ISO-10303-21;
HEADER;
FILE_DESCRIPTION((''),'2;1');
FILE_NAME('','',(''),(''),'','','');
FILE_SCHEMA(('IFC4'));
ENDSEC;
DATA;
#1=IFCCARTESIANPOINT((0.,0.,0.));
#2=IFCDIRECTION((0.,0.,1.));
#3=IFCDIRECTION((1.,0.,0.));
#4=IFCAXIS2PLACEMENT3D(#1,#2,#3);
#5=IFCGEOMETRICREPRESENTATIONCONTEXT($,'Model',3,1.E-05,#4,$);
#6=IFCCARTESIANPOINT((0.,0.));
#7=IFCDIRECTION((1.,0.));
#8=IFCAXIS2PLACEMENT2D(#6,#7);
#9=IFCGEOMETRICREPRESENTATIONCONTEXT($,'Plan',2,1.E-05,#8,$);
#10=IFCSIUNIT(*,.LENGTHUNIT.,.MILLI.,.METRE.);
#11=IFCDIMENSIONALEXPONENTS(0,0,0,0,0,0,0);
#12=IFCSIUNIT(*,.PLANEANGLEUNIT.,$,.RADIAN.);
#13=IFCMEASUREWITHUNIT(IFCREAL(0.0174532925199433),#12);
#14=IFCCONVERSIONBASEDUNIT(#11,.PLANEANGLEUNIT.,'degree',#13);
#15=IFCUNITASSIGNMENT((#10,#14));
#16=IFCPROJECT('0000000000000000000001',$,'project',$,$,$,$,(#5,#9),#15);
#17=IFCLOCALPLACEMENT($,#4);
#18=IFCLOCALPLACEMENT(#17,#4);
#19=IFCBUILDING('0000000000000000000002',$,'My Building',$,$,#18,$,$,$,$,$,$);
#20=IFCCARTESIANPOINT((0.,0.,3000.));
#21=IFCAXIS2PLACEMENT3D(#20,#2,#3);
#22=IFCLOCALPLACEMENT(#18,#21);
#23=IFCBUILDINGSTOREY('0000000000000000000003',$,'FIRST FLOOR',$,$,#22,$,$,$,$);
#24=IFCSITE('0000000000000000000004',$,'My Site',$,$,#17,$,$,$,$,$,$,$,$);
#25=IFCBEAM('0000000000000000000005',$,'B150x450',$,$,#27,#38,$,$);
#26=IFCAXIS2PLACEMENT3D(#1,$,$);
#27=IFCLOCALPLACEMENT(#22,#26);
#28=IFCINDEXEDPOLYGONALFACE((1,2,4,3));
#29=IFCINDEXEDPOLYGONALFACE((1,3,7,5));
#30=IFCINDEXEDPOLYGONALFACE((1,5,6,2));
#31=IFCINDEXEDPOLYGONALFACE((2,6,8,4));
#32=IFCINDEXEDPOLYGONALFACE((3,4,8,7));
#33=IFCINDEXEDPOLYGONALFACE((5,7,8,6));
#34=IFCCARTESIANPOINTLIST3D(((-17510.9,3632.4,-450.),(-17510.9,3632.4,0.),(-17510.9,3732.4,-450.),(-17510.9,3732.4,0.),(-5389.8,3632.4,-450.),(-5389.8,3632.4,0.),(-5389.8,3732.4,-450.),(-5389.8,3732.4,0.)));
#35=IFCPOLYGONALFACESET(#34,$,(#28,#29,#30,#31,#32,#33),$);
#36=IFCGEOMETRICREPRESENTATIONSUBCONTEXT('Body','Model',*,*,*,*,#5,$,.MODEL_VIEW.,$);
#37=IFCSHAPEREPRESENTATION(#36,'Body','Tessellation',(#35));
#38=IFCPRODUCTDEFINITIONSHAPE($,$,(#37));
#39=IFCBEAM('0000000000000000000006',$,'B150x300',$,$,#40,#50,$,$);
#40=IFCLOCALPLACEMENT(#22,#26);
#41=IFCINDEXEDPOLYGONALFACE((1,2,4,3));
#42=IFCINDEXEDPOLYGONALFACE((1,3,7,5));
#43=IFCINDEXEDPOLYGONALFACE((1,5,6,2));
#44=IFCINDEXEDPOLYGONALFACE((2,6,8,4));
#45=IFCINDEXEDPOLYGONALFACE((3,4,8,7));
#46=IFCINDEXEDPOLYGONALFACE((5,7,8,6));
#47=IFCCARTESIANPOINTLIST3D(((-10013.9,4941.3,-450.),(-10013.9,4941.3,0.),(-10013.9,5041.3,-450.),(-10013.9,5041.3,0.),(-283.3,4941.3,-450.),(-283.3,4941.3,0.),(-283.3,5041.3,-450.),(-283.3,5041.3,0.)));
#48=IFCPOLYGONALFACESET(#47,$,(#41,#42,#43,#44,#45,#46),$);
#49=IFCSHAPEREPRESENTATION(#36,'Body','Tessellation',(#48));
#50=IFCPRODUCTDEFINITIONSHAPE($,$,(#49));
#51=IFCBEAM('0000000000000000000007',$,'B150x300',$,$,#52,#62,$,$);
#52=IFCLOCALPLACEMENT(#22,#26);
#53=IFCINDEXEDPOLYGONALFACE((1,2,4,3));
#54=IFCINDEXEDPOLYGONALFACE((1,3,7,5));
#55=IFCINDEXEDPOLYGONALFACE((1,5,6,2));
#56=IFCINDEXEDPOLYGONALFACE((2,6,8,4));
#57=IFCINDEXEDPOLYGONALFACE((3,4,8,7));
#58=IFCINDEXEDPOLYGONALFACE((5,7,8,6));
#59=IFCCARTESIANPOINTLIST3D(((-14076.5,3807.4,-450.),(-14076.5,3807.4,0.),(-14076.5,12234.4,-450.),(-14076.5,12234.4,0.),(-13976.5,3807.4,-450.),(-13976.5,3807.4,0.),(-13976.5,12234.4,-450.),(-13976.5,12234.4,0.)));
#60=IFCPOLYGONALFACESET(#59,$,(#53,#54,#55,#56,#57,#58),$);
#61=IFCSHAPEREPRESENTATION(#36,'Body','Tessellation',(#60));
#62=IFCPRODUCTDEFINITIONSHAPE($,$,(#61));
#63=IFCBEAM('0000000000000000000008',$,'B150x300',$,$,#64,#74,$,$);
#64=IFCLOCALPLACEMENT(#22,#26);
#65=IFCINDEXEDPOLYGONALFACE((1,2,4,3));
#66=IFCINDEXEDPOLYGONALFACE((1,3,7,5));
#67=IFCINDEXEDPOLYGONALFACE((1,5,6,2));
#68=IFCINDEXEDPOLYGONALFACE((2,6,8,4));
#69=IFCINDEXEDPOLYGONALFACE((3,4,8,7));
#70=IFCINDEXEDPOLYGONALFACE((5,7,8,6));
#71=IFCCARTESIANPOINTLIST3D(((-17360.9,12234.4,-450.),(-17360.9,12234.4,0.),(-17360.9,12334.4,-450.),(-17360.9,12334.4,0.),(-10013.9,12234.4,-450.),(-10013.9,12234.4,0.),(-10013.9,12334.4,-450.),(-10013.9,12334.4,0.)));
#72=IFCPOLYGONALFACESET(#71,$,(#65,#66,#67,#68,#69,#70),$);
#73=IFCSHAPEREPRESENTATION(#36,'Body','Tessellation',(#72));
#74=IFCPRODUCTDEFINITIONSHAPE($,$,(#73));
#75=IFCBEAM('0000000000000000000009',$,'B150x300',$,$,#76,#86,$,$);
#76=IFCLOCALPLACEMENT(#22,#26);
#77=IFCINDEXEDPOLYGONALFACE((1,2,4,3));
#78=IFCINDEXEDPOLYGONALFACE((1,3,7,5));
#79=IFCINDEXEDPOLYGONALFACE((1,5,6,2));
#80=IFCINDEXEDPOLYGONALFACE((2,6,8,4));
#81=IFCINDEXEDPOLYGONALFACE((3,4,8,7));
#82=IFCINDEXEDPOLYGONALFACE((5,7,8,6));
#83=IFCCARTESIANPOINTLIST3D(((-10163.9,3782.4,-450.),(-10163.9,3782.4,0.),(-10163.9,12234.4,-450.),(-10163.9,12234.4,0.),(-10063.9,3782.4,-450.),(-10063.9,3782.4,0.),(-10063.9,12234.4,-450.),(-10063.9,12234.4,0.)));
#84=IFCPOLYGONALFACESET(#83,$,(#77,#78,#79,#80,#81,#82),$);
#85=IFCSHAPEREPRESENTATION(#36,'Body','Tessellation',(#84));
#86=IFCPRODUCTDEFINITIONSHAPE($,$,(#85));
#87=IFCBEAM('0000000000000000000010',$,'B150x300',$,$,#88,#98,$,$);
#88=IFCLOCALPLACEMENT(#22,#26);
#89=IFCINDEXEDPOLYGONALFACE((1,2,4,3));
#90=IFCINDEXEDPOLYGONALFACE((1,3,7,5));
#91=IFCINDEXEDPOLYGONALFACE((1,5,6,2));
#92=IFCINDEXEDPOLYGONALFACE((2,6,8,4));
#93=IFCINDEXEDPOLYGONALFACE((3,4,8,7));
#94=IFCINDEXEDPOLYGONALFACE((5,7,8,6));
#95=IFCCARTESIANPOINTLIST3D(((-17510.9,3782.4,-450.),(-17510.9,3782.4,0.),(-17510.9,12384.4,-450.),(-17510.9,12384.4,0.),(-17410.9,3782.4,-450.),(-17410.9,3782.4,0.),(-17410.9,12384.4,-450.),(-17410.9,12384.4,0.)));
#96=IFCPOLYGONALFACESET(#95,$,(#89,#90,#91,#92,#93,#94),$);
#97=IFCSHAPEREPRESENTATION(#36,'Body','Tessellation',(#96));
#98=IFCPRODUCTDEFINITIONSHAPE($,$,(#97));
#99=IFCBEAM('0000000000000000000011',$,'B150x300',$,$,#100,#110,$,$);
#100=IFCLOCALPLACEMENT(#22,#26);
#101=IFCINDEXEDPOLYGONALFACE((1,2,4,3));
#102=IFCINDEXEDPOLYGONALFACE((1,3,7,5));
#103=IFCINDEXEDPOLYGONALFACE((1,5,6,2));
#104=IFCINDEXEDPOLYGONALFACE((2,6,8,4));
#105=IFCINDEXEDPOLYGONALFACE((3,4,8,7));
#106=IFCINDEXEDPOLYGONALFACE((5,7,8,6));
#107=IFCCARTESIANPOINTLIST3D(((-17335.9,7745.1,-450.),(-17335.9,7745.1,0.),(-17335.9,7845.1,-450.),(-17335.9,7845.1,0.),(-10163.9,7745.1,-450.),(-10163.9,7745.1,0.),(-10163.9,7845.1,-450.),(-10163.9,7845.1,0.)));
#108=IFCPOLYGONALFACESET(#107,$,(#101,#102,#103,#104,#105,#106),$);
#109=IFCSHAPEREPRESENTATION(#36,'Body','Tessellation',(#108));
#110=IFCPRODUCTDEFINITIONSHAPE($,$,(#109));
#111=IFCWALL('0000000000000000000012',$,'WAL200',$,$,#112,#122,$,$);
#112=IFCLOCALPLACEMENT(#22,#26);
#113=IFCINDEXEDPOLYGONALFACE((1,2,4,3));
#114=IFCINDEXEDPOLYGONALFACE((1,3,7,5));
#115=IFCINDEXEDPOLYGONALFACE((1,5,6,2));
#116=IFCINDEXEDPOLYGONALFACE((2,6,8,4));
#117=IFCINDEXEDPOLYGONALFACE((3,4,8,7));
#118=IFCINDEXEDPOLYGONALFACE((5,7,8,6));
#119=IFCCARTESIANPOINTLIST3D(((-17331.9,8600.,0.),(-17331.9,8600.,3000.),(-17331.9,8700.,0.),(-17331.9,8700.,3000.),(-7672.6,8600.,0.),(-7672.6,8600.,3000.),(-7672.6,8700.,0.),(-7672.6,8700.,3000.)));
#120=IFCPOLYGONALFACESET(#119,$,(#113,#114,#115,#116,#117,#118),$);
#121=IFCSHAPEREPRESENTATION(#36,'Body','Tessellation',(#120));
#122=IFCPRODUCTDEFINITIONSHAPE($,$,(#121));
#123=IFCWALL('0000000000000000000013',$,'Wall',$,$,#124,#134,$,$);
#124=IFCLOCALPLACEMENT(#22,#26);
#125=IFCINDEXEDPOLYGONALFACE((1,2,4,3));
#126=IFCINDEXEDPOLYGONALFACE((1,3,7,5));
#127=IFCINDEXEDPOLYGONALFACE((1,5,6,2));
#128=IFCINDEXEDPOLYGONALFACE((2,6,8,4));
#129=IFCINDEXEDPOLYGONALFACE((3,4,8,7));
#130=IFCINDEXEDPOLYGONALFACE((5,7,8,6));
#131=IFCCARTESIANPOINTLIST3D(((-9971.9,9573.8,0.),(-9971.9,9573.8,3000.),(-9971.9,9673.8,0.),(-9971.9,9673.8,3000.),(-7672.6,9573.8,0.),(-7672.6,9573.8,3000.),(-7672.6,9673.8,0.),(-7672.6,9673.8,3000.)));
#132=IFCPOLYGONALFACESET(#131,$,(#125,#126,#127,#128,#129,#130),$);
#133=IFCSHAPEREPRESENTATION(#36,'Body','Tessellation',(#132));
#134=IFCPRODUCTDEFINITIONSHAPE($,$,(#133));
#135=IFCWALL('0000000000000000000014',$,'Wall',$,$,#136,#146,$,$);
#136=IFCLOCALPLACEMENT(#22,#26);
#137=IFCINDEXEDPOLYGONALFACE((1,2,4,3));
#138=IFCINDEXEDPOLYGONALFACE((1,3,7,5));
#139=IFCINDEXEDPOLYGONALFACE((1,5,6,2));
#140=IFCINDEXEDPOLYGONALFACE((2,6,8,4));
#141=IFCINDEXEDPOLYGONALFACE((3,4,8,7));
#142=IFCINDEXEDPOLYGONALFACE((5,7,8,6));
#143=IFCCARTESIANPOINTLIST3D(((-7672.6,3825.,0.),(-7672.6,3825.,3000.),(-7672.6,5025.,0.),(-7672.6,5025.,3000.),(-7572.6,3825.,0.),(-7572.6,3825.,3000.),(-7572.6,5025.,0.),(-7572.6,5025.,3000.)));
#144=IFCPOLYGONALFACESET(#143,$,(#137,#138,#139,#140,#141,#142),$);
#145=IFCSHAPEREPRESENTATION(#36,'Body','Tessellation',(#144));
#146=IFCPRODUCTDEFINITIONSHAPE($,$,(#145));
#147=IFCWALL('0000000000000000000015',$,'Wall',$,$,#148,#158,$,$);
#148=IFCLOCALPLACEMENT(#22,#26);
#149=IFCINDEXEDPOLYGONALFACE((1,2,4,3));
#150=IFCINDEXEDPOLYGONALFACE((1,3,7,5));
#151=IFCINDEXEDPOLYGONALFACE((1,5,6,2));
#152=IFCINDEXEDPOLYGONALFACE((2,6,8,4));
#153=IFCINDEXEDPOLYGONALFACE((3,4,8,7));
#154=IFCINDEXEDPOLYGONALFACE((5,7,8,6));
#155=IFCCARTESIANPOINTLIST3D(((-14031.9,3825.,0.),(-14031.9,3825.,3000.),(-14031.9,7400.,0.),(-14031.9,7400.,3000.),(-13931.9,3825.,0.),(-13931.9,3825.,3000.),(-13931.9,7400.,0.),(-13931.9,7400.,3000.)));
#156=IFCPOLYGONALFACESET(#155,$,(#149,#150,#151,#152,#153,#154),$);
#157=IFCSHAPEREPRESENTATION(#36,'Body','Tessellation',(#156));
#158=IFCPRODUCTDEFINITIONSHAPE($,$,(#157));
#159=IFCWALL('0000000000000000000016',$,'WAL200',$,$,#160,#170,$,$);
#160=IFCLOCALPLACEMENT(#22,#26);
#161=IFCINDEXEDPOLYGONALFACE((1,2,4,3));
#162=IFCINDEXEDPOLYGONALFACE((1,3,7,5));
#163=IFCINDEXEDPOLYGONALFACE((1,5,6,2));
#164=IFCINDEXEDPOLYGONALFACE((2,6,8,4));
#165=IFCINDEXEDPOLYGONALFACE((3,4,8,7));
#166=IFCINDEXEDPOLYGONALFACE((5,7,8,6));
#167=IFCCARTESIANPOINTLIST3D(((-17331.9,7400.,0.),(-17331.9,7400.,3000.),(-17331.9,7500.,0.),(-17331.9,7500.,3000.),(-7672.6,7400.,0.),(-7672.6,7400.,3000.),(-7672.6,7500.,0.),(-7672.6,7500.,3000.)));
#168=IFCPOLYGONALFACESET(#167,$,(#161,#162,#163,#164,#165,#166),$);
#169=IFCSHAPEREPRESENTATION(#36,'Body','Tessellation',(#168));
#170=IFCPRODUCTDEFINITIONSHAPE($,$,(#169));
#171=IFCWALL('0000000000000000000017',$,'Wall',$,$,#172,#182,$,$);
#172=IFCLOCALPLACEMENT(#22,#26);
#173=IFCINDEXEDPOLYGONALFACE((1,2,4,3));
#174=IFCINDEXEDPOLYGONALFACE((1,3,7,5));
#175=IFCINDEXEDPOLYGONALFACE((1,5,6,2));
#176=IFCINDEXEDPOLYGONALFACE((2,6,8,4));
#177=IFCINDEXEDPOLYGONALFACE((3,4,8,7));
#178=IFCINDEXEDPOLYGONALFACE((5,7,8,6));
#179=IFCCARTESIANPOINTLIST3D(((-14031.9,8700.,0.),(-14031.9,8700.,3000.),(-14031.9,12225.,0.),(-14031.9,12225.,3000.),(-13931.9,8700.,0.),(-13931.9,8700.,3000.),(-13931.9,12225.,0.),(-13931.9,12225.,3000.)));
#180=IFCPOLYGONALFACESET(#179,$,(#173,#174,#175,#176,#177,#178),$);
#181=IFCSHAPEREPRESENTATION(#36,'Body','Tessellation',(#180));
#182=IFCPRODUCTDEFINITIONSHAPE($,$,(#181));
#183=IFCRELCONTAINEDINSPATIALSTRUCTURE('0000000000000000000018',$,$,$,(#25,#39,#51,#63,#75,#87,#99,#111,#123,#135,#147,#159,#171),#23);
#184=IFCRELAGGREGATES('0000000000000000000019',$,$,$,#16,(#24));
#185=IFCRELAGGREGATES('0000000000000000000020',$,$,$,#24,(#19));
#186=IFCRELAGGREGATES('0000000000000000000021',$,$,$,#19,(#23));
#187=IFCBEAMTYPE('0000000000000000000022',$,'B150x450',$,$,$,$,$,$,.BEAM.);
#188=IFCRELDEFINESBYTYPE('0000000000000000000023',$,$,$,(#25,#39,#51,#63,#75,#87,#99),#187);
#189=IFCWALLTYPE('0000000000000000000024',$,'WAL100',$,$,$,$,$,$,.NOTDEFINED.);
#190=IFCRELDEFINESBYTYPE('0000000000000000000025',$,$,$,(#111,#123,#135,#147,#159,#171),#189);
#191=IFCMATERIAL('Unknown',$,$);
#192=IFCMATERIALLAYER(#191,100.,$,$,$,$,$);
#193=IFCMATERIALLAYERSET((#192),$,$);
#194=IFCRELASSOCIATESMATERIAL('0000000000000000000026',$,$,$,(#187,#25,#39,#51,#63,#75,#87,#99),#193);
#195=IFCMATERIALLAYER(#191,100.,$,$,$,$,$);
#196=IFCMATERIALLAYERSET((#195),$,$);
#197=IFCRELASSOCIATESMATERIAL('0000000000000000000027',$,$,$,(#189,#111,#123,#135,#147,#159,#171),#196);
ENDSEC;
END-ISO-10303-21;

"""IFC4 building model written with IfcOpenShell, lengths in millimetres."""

from ifc_helpers import new_model, entity, si_unit, converted_unit, frame, origin_with_axes, origin_2d_with_axis, place, context, subcontext, project, spatial, indexed_curve, outline, extrude, material, layer, layer_set, layer_usage, type_object, element, save


model = new_model("IFC4")

# Units and contexts
model_context = context("Model", 3, precision=1e-05, world=origin_with_axes())
plan_context = context("Plan", 2, precision=1e-05, world=origin_2d_with_axis())
body_context_1 = subcontext(model_context, "Body", "Model", "MODEL_VIEW")
ifc_project = project(units=[si_unit("LENGTHUNIT", "METRE", prefix="MILLI"), converted_unit("PLANEANGLEUNIT", "degree", entity("IfcReal", 0.0174532925199433), si_unit("PLANEANGLEUNIT", "RADIAN"), dimensions=[0, 0, 0, 0, 0, 0, 0])], contexts=[model_context, plan_context])

# Site, building, storey
site_placement = place(None, origin_with_axes())
site = spatial("IfcSite", under=ifc_project, at=site_placement, Name="My Site")
building_placement = place(site_placement, origin_with_axes())
building = spatial("IfcBuilding", under=site, at=building_placement, Name="My Building")
storey_placement = place(building_placement, frame((0.0, 0.0, 3000.0), z_axis=(0.0, 0.0, 1.0), x_axis=(1.0, 0.0, 0.0)))
storey = spatial("IfcBuildingStorey", under=building, at=storey_placement, Name="FIRST FLOOR")

# Beams
ifc_material = material(Name="Unknown")
ifc_layer_1 = layer(ifc_material, 100.0)
ifc_layer_set_1 = layer_set([ifc_layer_1])
ifc_layer_usage_1 = layer_usage(ifc_layer_set_1, "AXIS2", "POSITIVE", 0.0)
beam_type = type_object("IfcBeamType", Name="B150x450", PredefinedType="BEAM", material=ifc_layer_set_1)
beam_1_placement = place(storey_placement, frame((-17510.9, 3632.4, -450.0), z_axis=(0.0, 0.0, 1.0), x_axis=(1.0, 0.0, 0.0)))
element("IfcBeam", 1, at=beam_1_placement, inside=storey, type_object=beam_type, material=ifc_layer_usage_1, Name="B150x450", context=body_context_1, shape_type="SweptSolid", body=[
    extrude(outline(indexed_curve([(0.0, 0.0), (0.0, 100.0), (12121.1, 100.0), (12121.1, 0.0), (0.0, 0.0)], self_intersect=False)), origin_with_axes(), (0.0, 0.0, 1.0), 450.0),
])
ifc_layer_usage_2 = layer_usage(ifc_layer_set_1, "AXIS2", "POSITIVE", 0.0)
beam_2_placement = place(storey_placement, frame((-10013.9, 4941.3, -450.0), z_axis=(0.0, 0.0, 1.0), x_axis=(1.0, 0.0, 0.0)))
element("IfcBeam", 2, at=beam_2_placement, inside=storey, type_object=beam_type, material=ifc_layer_usage_2, Name="B150x300", context=body_context_1, shape_type="SweptSolid", body=[
    extrude(outline(indexed_curve([(0.0, 0.0), (0.0, 100.0), (9730.7, 100.0), (9730.7, 0.0), (0.0, 0.0)], self_intersect=False)), origin_with_axes(), (0.0, 0.0, 1.0), 450.0),
])
ifc_layer_usage_3 = layer_usage(ifc_layer_set_1, "AXIS2", "POSITIVE", 0.0)
beam_3_placement = place(storey_placement, frame((-14076.5, 12234.4, -450.0), z_axis=(0.0, 0.0, 1.0), x_axis=(0.0, -1.0, 0.0)))
element("IfcBeam", 3, at=beam_3_placement, inside=storey, type_object=beam_type, material=ifc_layer_usage_3, Name="B150x300", context=body_context_1, shape_type="SweptSolid", body=[
    extrude(outline(indexed_curve([(0.0, 0.0), (0.0, 100.0), (8427.0, 100.0), (8427.0, 0.0), (0.0, 0.0)], self_intersect=False)), origin_with_axes(), (0.0, 0.0, 1.0), 450.0),
])
ifc_layer_usage_4 = layer_usage(ifc_layer_set_1, "AXIS2", "POSITIVE", 0.0)
beam_4_placement = place(storey_placement, frame((-17360.9, 12234.4, -450.0), z_axis=(0.0, 0.0, 1.0), x_axis=(1.0, 0.0, 0.0)))
element("IfcBeam", 4, at=beam_4_placement, inside=storey, type_object=beam_type, material=ifc_layer_usage_4, Name="B150x300", context=body_context_1, shape_type="SweptSolid", body=[
    extrude(outline(indexed_curve([(0.0, 0.0), (0.0, 100.0), (7347.0, 100.0), (7347.0, 0.0), (0.0, 0.0)], self_intersect=False)), origin_with_axes(), (0.0, 0.0, 1.0), 450.0),
])
ifc_layer_usage_5 = layer_usage(ifc_layer_set_1, "AXIS2", "POSITIVE", 0.0)
beam_5_placement = place(storey_placement, frame((-10163.9, 12234.4, -450.0), z_axis=(0.0, 0.0, 1.0), x_axis=(0.0, -1.0, 0.0)))
element("IfcBeam", 5, at=beam_5_placement, inside=storey, type_object=beam_type, material=ifc_layer_usage_5, Name="B150x300", context=body_context_1, shape_type="SweptSolid", body=[
    extrude(outline(indexed_curve([(0.0, 0.0), (0.0, 100.0), (8452.0, 100.0), (8452.0, 0.0), (0.0, 0.0)], self_intersect=False)), origin_with_axes(), (0.0, 0.0, 1.0), 450.0),
])
ifc_layer_usage_6 = layer_usage(ifc_layer_set_1, "AXIS2", "POSITIVE", 0.0)
beam_6_placement = place(storey_placement, frame((-17510.9, 12384.4, -450.0), z_axis=(0.0, 0.0, 1.0), x_axis=(0.0, -1.0, 0.0)))
element("IfcBeam", 6, at=beam_6_placement, inside=storey, type_object=beam_type, material=ifc_layer_usage_6, Name="B150x300", context=body_context_1, shape_type="SweptSolid", body=[
    extrude(outline(indexed_curve([(0.0, 0.0), (0.0, 100.0), (8602.0, 100.0), (8602.0, 0.0), (0.0, 0.0)], self_intersect=False)), origin_with_axes(), (0.0, 0.0, 1.0), 450.0),
])
ifc_layer_usage_7 = layer_usage(ifc_layer_set_1, "AXIS2", "POSITIVE", 0.0)
beam_7_placement = place(storey_placement, frame((-17335.9, 7745.1, -450.0), z_axis=(0.0, 0.0, 1.0), x_axis=(1.0, 0.0, 0.0)))
element("IfcBeam", 7, at=beam_7_placement, inside=storey, type_object=beam_type, material=ifc_layer_usage_7, Name="B150x300", context=body_context_1, shape_type="SweptSolid", body=[
    extrude(outline(indexed_curve([(0.0, 0.0), (0.0, 100.0), (7172.0, 100.0), (7172.0, 0.0), (0.0, 0.0)], self_intersect=False)), origin_with_axes(), (0.0, 0.0, 1.0), 450.0),
])

# Walls
ifc_layer_2 = layer(ifc_material, 100.0)
ifc_layer_set_2 = layer_set([ifc_layer_2])
ifc_layer_usage_8 = layer_usage(ifc_layer_set_2, "AXIS2", "POSITIVE", 0.0)
wall_type_1 = type_object("IfcWallType", Name="WAL100", PredefinedType="NOTDEFINED", material=ifc_layer_set_2)
wall_1_placement = place(storey_placement, frame((-7672.6, 8700.0, 0.0), z_axis=(0.0, 0.0, 1.0), x_axis=(-1.0, 0.0, 0.0)))
element("IfcWall", 8, at=wall_1_placement, inside=storey, type_object=wall_type_1, material=ifc_layer_usage_8, Name="WAL200", context=body_context_1, shape_type="SweptSolid", body=[
    extrude(outline(indexed_curve([(0.0, 0.0), (0.0, 100.0), (9659.3, 100.0), (9659.3, 0.0), (0.0, 0.0)], self_intersect=False)), origin_with_axes(), (0.0, 0.0, 1.0), 3000.0),
])
ifc_layer_usage_9 = layer_usage(ifc_layer_set_2, "AXIS2", "POSITIVE", 0.0)
wall_2_placement = place(storey_placement, frame((-9971.9, 9573.8, 0.0), z_axis=(0.0, 0.0, 1.0), x_axis=(1.0, 0.0, 0.0)))
element("IfcWall", 9, at=wall_2_placement, inside=storey, type_object=wall_type_1, material=ifc_layer_usage_9, Name="Wall", context=body_context_1, shape_type="SweptSolid", body=[
    extrude(outline(indexed_curve([(0.0, 0.0), (0.0, 100.0), (2299.3, 100.0), (2299.3, 0.0), (0.0, 0.0)], self_intersect=False)), origin_with_axes(), (0.0, 0.0, 1.0), 3000.0),
])
ifc_layer_usage_10 = layer_usage(ifc_layer_set_2, "AXIS2", "POSITIVE", 0.0)
wall_3_placement = place(storey_placement, frame((-7572.6, 3825.0, 0.0), z_axis=(0.0, 0.0, 1.0), x_axis=(0.000001, 1.0, 0.0)))
element("IfcWall", 10, at=wall_3_placement, inside=storey, type_object=wall_type_1, material=ifc_layer_usage_10, Name="Wall", context=body_context_1, shape_type="SweptSolid", body=[
    extrude(outline(indexed_curve([(0.0, 0.0), (0.0, 100.0), (1200.0, 100.0), (1200.0, 0.0), (0.0, 0.0)], self_intersect=False)), origin_with_axes(), (0.0, 0.0, 1.0), 3000.0),
])
ifc_layer_usage_11 = layer_usage(ifc_layer_set_2, "AXIS2", "POSITIVE", 0.0)
wall_4_placement = place(storey_placement, frame((-13931.9, 3825.0, 0.0), z_axis=(0.0, 0.0, 1.0), x_axis=(0.000001, 1.0, 0.0)))
element("IfcWall", 11, at=wall_4_placement, inside=storey, type_object=wall_type_1, material=ifc_layer_usage_11, Name="Wall", context=body_context_1, shape_type="SweptSolid", body=[
    extrude(outline(indexed_curve([(0.0, 0.0), (0.0, 100.0), (3575.0, 100.0), (3575.0, 0.0), (0.0, 0.0)], self_intersect=False)), origin_with_axes(), (0.0, 0.0, 1.0), 3000.0),
])
ifc_layer_usage_12 = layer_usage(ifc_layer_set_2, "AXIS2", "POSITIVE", 0.0)
wall_5_placement = place(storey_placement, frame((-7672.6, 7500.0, 0.0), z_axis=(0.0, 0.0, 1.0), x_axis=(-1.0, 0.0, 0.0)))
element("IfcWall", 12, at=wall_5_placement, inside=storey, type_object=wall_type_1, material=ifc_layer_usage_12, Name="WAL200", context=body_context_1, shape_type="SweptSolid", body=[
    extrude(outline(indexed_curve([(0.0, 0.0), (0.0, 100.0), (9659.3, 100.0), (9659.3, 0.0), (0.0, 0.0)], self_intersect=False)), origin_with_axes(), (0.0, 0.0, 1.0), 3000.0),
])
ifc_layer_usage_13 = layer_usage(ifc_layer_set_2, "AXIS2", "POSITIVE", 0.0)
wall_6_placement = place(storey_placement, frame((-13931.9, 8700.0, 0.0), z_axis=(0.0, 0.0, 1.0), x_axis=(0.000001, 1.0, 0.0)))
element("IfcWall", 13, at=wall_6_placement, inside=storey, type_object=wall_type_1, material=ifc_layer_usage_13, Name="Wall", context=body_context_1, shape_type="SweptSolid", body=[
    extrude(outline(indexed_curve([(0.0, 0.0), (0.0, 100.0), (3525.0, 100.0), (3525.0, 0.0), (0.0, 0.0)], self_intersect=False)), origin_with_axes(), (0.0, 0.0, 1.0), 3000.0),
])

save(model, "model.ifc")
